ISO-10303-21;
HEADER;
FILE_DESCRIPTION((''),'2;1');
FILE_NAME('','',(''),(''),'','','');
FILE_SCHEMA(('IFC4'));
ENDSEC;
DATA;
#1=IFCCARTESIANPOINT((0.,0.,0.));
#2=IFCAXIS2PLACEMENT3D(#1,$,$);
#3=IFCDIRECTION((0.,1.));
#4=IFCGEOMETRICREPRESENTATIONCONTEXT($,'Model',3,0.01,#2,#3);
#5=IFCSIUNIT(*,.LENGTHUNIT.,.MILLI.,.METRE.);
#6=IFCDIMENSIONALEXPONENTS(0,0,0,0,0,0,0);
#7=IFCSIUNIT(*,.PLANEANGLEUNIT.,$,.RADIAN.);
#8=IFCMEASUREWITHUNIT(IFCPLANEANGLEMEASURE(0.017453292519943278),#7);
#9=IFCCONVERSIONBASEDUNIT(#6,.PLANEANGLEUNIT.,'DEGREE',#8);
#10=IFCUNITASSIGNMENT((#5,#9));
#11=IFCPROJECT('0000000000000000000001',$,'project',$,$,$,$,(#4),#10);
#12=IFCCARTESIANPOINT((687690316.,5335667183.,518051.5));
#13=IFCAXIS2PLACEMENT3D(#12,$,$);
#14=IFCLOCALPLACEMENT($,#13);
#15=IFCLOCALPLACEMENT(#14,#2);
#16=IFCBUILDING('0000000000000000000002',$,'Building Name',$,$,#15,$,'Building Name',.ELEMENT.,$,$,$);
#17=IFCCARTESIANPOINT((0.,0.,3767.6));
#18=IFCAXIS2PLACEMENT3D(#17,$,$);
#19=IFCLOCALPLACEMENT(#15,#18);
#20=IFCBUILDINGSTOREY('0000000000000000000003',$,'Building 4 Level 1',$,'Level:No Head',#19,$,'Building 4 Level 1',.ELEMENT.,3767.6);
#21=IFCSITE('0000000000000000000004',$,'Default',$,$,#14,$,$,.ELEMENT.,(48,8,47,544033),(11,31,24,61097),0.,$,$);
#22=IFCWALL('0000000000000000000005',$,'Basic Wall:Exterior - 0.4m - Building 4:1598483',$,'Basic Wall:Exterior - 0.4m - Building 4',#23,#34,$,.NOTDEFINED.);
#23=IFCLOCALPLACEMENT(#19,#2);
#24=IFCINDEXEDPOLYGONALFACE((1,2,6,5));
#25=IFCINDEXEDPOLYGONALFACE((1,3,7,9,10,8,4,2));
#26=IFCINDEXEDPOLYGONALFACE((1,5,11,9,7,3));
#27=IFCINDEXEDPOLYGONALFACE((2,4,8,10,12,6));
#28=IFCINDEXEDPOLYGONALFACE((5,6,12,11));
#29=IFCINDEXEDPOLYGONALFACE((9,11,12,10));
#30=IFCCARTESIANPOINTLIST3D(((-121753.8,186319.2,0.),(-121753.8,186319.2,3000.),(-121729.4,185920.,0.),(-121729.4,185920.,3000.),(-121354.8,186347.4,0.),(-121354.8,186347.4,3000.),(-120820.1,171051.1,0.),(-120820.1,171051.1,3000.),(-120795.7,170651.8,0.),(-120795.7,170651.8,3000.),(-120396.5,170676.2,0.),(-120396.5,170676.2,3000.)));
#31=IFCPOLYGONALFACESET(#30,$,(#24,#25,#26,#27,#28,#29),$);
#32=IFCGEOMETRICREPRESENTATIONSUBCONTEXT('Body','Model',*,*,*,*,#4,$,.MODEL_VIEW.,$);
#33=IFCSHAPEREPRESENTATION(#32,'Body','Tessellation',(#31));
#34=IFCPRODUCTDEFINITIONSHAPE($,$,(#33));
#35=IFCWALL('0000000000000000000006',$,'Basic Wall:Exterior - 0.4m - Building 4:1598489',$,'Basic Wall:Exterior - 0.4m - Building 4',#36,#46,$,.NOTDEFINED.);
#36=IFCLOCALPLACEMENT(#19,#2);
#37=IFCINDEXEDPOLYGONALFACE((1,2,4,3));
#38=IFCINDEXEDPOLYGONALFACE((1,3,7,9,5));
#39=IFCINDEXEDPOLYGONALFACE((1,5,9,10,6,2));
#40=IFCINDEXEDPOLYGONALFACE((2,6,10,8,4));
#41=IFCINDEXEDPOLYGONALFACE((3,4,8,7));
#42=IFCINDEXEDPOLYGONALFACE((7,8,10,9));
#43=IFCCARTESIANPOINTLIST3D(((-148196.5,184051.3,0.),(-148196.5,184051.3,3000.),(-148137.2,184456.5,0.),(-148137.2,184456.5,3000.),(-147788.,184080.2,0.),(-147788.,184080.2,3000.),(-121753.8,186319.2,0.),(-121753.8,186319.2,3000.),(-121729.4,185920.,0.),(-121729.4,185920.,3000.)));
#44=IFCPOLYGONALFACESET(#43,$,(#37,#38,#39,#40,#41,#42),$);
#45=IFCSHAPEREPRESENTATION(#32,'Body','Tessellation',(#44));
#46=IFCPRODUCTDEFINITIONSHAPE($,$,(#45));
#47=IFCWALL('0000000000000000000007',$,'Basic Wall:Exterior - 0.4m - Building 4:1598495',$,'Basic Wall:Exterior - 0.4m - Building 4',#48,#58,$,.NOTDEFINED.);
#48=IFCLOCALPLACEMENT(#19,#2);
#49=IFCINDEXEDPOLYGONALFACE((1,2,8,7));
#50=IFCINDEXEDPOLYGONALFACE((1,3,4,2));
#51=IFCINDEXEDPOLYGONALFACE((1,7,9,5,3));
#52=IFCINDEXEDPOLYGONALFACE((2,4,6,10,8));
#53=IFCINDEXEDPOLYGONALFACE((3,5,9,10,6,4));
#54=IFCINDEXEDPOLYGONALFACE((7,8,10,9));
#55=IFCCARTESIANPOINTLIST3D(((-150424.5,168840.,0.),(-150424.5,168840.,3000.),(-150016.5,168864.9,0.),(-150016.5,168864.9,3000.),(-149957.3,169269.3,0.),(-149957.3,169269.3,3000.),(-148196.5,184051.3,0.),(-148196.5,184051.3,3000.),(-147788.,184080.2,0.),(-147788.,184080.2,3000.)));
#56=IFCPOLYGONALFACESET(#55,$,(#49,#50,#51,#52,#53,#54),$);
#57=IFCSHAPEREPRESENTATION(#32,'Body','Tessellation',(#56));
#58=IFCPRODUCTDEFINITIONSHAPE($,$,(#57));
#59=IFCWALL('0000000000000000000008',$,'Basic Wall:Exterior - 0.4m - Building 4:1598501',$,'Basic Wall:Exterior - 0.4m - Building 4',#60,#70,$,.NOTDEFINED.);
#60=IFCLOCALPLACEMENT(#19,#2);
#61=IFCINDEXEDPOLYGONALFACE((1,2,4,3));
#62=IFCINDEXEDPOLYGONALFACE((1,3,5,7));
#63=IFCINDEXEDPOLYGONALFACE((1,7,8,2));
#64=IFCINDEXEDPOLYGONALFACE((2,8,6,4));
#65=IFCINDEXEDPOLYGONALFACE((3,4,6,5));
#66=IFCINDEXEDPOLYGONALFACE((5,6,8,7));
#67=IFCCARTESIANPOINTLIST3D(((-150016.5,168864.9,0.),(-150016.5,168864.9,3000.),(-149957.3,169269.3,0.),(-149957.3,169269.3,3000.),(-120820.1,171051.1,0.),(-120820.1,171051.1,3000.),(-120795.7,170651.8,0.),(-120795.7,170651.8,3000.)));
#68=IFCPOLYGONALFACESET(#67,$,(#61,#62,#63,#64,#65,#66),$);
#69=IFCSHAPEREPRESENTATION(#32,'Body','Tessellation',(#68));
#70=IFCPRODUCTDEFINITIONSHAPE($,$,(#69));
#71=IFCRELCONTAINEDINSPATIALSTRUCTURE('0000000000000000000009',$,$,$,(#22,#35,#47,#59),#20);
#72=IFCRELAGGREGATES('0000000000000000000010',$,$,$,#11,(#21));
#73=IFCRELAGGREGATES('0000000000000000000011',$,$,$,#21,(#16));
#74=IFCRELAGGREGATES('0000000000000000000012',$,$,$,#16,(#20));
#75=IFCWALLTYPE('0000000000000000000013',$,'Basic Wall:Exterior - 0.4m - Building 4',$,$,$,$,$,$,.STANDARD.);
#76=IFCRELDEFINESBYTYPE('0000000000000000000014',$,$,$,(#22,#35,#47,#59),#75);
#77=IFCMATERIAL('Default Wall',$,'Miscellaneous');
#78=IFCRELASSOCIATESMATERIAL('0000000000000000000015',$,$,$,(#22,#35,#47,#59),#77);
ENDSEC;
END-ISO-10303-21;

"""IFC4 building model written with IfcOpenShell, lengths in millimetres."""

from ifc_helpers import new_model, entity, si_unit, converted_unit, direction, frame, origin, place, context, subcontext, project, spatial, indexed_curve, outline, extrude, material, type_object, element, save


model = new_model("IFC4")

# Units and contexts
model_context = context("Model", 3, precision=0.01, world=origin(), true_north=direction((0.0, 1.0)))
body_context = subcontext(model_context, "Body", "Model", "MODEL_VIEW")
ifc_project = project(units=[si_unit("LENGTHUNIT", "METRE", prefix="MILLI"), converted_unit("PLANEANGLEUNIT", "DEGREE", entity("IfcPlaneAngleMeasure", 0.017453292519943278), si_unit("PLANEANGLEUNIT", "RADIAN"), dimensions=[0, 0, 0, 0, 0, 0, 0])], contexts=[model_context])

# Site, building, storey
site_placement = place(None, frame((687690316.0, 5335667183.0, 518051.5)))
site = spatial("IfcSite", under=ifc_project, at=site_placement, Name="Default", CompositionType="ELEMENT", RefLatitude=(48, 8, 47, 544033), RefLongitude=(11, 31, 24, 61097), RefElevation=0.0)
building_placement = place(site_placement, origin())
building = spatial("IfcBuilding", under=site, at=building_placement, Name="Building Name", LongName="Building Name", CompositionType="ELEMENT")
storey_placement = place(building_placement, frame((0.0, 0.0, 3767.6)))
storey = spatial("IfcBuildingStorey", under=building, at=storey_placement, Name="Building 4 Level 1", ObjectType="Level:No Head", LongName="Building 4 Level 1", CompositionType="ELEMENT", Elevation=3767.6)

# Walls
ifc_material_1 = material(Name="Default Wall", Category="Miscellaneous")
wall_type = type_object("IfcWallType", Name="Basic Wall:Exterior - 0.4m - Building 4", PredefinedType="STANDARD")
wall_1_placement = place(storey_placement, frame((-120596.1, 170664.0, 0.0), z_axis=(0.0, 0.0, 1.0), x_axis=(-0.061037, 0.998136, 0.0)))
element("IfcWall", 1, at=wall_1_placement, inside=storey, type_object=wall_type, material=ifc_material_1, Name="Basic Wall:Exterior - 0.4m - Building 4:1598483", ObjectType="Basic Wall:Exterior - 0.4m - Building 4", PredefinedType="NOTDEFINED", context=body_context, shape_type="SweptSolid", body=[
    extrude(outline(indexed_curve([(15700.4, -200.0), (15696.7, 200.0), (15296.7, 200.0), (400.0, 200.0), (0.0, 200.0), (0.0, -200.0), (15700.4, -200.0)], self_intersect=False)), origin(), (0.0, 0.0, 1.0), 3000.0),
])
wall_2_placement = place(storey_placement, frame((-121739.7, 186119.7, 0.0), z_axis=(0.0, 0.0, 1.0), x_axis=(-0.997517, -0.070427, 0.0)))
element("IfcWall", 2, at=wall_2_placement, inside=storey, type_object=wall_type, material=ifc_material_1, Name="Basic Wall:Exterior - 0.4m - Building 4:1598489", ObjectType="Basic Wall:Exterior - 0.4m - Building 4", PredefinedType="NOTDEFINED", context=body_context, shape_type="SweptSolid", body=[
    extrude(outline(indexed_curve([(26449.1, -200.0), (26536.8, 200.0), (26127.3, 200.0), (3.8, 200.0), (0.0, -200.0), (26449.1, -200.0)], self_intersect=False)), origin(), (0.0, 0.0, 1.0), 3000.0),
])
wall_3_placement = place(storey_placement, frame((-147985.9, 184109.1, 0.0), z_axis=(0.0, 0.0, 1.0), x_axis=(-0.144921, -0.989443, 0.0)))
element("IfcWall", 3, at=wall_3_placement, inside=storey, type_object=wall_type, material=ifc_material_1, Name="Basic Wall:Exterior - 0.4m - Building 4:1598495", ObjectType="Basic Wall:Exterior - 0.4m - Building 4", PredefinedType="NOTDEFINED", context=body_context, shape_type="SweptSolid", body=[
    extrude(outline(indexed_curve([(15461.4, -200.0), (15377.6, 200.0), (14968.9, 200.0), (0.0, 200.0), (87.7, -200.0), (15461.4, -200.0)], self_intersect=False)), origin(), (0.0, 0.0, 1.0), 3000.0),
])
wall_4_placement = place(storey_placement, frame((-150028.8, 169064.6, 0.0), z_axis=(0.0, 0.0, 1.0), x_axis=(0.998136, 0.061037, 0.0)))
element("IfcWall", 4, at=wall_4_placement, inside=storey, type_object=wall_type, material=ifc_material_1, Name="Basic Wall:Exterior - 0.4m - Building 4:1598501", ObjectType="Basic Wall:Exterior - 0.4m - Building 4", PredefinedType="NOTDEFINED", context=body_context, shape_type="SweptSolid", body=[
    extrude(outline(indexed_curve([(29275.4, -200.0), (29275.4, 200.0), (83.8, 200.0), (0.0, -200.0), (29275.4, -200.0)], self_intersect=False)), origin(), (0.0, 0.0, 1.0), 3000.0),
])

save(model, "model.ifc")
